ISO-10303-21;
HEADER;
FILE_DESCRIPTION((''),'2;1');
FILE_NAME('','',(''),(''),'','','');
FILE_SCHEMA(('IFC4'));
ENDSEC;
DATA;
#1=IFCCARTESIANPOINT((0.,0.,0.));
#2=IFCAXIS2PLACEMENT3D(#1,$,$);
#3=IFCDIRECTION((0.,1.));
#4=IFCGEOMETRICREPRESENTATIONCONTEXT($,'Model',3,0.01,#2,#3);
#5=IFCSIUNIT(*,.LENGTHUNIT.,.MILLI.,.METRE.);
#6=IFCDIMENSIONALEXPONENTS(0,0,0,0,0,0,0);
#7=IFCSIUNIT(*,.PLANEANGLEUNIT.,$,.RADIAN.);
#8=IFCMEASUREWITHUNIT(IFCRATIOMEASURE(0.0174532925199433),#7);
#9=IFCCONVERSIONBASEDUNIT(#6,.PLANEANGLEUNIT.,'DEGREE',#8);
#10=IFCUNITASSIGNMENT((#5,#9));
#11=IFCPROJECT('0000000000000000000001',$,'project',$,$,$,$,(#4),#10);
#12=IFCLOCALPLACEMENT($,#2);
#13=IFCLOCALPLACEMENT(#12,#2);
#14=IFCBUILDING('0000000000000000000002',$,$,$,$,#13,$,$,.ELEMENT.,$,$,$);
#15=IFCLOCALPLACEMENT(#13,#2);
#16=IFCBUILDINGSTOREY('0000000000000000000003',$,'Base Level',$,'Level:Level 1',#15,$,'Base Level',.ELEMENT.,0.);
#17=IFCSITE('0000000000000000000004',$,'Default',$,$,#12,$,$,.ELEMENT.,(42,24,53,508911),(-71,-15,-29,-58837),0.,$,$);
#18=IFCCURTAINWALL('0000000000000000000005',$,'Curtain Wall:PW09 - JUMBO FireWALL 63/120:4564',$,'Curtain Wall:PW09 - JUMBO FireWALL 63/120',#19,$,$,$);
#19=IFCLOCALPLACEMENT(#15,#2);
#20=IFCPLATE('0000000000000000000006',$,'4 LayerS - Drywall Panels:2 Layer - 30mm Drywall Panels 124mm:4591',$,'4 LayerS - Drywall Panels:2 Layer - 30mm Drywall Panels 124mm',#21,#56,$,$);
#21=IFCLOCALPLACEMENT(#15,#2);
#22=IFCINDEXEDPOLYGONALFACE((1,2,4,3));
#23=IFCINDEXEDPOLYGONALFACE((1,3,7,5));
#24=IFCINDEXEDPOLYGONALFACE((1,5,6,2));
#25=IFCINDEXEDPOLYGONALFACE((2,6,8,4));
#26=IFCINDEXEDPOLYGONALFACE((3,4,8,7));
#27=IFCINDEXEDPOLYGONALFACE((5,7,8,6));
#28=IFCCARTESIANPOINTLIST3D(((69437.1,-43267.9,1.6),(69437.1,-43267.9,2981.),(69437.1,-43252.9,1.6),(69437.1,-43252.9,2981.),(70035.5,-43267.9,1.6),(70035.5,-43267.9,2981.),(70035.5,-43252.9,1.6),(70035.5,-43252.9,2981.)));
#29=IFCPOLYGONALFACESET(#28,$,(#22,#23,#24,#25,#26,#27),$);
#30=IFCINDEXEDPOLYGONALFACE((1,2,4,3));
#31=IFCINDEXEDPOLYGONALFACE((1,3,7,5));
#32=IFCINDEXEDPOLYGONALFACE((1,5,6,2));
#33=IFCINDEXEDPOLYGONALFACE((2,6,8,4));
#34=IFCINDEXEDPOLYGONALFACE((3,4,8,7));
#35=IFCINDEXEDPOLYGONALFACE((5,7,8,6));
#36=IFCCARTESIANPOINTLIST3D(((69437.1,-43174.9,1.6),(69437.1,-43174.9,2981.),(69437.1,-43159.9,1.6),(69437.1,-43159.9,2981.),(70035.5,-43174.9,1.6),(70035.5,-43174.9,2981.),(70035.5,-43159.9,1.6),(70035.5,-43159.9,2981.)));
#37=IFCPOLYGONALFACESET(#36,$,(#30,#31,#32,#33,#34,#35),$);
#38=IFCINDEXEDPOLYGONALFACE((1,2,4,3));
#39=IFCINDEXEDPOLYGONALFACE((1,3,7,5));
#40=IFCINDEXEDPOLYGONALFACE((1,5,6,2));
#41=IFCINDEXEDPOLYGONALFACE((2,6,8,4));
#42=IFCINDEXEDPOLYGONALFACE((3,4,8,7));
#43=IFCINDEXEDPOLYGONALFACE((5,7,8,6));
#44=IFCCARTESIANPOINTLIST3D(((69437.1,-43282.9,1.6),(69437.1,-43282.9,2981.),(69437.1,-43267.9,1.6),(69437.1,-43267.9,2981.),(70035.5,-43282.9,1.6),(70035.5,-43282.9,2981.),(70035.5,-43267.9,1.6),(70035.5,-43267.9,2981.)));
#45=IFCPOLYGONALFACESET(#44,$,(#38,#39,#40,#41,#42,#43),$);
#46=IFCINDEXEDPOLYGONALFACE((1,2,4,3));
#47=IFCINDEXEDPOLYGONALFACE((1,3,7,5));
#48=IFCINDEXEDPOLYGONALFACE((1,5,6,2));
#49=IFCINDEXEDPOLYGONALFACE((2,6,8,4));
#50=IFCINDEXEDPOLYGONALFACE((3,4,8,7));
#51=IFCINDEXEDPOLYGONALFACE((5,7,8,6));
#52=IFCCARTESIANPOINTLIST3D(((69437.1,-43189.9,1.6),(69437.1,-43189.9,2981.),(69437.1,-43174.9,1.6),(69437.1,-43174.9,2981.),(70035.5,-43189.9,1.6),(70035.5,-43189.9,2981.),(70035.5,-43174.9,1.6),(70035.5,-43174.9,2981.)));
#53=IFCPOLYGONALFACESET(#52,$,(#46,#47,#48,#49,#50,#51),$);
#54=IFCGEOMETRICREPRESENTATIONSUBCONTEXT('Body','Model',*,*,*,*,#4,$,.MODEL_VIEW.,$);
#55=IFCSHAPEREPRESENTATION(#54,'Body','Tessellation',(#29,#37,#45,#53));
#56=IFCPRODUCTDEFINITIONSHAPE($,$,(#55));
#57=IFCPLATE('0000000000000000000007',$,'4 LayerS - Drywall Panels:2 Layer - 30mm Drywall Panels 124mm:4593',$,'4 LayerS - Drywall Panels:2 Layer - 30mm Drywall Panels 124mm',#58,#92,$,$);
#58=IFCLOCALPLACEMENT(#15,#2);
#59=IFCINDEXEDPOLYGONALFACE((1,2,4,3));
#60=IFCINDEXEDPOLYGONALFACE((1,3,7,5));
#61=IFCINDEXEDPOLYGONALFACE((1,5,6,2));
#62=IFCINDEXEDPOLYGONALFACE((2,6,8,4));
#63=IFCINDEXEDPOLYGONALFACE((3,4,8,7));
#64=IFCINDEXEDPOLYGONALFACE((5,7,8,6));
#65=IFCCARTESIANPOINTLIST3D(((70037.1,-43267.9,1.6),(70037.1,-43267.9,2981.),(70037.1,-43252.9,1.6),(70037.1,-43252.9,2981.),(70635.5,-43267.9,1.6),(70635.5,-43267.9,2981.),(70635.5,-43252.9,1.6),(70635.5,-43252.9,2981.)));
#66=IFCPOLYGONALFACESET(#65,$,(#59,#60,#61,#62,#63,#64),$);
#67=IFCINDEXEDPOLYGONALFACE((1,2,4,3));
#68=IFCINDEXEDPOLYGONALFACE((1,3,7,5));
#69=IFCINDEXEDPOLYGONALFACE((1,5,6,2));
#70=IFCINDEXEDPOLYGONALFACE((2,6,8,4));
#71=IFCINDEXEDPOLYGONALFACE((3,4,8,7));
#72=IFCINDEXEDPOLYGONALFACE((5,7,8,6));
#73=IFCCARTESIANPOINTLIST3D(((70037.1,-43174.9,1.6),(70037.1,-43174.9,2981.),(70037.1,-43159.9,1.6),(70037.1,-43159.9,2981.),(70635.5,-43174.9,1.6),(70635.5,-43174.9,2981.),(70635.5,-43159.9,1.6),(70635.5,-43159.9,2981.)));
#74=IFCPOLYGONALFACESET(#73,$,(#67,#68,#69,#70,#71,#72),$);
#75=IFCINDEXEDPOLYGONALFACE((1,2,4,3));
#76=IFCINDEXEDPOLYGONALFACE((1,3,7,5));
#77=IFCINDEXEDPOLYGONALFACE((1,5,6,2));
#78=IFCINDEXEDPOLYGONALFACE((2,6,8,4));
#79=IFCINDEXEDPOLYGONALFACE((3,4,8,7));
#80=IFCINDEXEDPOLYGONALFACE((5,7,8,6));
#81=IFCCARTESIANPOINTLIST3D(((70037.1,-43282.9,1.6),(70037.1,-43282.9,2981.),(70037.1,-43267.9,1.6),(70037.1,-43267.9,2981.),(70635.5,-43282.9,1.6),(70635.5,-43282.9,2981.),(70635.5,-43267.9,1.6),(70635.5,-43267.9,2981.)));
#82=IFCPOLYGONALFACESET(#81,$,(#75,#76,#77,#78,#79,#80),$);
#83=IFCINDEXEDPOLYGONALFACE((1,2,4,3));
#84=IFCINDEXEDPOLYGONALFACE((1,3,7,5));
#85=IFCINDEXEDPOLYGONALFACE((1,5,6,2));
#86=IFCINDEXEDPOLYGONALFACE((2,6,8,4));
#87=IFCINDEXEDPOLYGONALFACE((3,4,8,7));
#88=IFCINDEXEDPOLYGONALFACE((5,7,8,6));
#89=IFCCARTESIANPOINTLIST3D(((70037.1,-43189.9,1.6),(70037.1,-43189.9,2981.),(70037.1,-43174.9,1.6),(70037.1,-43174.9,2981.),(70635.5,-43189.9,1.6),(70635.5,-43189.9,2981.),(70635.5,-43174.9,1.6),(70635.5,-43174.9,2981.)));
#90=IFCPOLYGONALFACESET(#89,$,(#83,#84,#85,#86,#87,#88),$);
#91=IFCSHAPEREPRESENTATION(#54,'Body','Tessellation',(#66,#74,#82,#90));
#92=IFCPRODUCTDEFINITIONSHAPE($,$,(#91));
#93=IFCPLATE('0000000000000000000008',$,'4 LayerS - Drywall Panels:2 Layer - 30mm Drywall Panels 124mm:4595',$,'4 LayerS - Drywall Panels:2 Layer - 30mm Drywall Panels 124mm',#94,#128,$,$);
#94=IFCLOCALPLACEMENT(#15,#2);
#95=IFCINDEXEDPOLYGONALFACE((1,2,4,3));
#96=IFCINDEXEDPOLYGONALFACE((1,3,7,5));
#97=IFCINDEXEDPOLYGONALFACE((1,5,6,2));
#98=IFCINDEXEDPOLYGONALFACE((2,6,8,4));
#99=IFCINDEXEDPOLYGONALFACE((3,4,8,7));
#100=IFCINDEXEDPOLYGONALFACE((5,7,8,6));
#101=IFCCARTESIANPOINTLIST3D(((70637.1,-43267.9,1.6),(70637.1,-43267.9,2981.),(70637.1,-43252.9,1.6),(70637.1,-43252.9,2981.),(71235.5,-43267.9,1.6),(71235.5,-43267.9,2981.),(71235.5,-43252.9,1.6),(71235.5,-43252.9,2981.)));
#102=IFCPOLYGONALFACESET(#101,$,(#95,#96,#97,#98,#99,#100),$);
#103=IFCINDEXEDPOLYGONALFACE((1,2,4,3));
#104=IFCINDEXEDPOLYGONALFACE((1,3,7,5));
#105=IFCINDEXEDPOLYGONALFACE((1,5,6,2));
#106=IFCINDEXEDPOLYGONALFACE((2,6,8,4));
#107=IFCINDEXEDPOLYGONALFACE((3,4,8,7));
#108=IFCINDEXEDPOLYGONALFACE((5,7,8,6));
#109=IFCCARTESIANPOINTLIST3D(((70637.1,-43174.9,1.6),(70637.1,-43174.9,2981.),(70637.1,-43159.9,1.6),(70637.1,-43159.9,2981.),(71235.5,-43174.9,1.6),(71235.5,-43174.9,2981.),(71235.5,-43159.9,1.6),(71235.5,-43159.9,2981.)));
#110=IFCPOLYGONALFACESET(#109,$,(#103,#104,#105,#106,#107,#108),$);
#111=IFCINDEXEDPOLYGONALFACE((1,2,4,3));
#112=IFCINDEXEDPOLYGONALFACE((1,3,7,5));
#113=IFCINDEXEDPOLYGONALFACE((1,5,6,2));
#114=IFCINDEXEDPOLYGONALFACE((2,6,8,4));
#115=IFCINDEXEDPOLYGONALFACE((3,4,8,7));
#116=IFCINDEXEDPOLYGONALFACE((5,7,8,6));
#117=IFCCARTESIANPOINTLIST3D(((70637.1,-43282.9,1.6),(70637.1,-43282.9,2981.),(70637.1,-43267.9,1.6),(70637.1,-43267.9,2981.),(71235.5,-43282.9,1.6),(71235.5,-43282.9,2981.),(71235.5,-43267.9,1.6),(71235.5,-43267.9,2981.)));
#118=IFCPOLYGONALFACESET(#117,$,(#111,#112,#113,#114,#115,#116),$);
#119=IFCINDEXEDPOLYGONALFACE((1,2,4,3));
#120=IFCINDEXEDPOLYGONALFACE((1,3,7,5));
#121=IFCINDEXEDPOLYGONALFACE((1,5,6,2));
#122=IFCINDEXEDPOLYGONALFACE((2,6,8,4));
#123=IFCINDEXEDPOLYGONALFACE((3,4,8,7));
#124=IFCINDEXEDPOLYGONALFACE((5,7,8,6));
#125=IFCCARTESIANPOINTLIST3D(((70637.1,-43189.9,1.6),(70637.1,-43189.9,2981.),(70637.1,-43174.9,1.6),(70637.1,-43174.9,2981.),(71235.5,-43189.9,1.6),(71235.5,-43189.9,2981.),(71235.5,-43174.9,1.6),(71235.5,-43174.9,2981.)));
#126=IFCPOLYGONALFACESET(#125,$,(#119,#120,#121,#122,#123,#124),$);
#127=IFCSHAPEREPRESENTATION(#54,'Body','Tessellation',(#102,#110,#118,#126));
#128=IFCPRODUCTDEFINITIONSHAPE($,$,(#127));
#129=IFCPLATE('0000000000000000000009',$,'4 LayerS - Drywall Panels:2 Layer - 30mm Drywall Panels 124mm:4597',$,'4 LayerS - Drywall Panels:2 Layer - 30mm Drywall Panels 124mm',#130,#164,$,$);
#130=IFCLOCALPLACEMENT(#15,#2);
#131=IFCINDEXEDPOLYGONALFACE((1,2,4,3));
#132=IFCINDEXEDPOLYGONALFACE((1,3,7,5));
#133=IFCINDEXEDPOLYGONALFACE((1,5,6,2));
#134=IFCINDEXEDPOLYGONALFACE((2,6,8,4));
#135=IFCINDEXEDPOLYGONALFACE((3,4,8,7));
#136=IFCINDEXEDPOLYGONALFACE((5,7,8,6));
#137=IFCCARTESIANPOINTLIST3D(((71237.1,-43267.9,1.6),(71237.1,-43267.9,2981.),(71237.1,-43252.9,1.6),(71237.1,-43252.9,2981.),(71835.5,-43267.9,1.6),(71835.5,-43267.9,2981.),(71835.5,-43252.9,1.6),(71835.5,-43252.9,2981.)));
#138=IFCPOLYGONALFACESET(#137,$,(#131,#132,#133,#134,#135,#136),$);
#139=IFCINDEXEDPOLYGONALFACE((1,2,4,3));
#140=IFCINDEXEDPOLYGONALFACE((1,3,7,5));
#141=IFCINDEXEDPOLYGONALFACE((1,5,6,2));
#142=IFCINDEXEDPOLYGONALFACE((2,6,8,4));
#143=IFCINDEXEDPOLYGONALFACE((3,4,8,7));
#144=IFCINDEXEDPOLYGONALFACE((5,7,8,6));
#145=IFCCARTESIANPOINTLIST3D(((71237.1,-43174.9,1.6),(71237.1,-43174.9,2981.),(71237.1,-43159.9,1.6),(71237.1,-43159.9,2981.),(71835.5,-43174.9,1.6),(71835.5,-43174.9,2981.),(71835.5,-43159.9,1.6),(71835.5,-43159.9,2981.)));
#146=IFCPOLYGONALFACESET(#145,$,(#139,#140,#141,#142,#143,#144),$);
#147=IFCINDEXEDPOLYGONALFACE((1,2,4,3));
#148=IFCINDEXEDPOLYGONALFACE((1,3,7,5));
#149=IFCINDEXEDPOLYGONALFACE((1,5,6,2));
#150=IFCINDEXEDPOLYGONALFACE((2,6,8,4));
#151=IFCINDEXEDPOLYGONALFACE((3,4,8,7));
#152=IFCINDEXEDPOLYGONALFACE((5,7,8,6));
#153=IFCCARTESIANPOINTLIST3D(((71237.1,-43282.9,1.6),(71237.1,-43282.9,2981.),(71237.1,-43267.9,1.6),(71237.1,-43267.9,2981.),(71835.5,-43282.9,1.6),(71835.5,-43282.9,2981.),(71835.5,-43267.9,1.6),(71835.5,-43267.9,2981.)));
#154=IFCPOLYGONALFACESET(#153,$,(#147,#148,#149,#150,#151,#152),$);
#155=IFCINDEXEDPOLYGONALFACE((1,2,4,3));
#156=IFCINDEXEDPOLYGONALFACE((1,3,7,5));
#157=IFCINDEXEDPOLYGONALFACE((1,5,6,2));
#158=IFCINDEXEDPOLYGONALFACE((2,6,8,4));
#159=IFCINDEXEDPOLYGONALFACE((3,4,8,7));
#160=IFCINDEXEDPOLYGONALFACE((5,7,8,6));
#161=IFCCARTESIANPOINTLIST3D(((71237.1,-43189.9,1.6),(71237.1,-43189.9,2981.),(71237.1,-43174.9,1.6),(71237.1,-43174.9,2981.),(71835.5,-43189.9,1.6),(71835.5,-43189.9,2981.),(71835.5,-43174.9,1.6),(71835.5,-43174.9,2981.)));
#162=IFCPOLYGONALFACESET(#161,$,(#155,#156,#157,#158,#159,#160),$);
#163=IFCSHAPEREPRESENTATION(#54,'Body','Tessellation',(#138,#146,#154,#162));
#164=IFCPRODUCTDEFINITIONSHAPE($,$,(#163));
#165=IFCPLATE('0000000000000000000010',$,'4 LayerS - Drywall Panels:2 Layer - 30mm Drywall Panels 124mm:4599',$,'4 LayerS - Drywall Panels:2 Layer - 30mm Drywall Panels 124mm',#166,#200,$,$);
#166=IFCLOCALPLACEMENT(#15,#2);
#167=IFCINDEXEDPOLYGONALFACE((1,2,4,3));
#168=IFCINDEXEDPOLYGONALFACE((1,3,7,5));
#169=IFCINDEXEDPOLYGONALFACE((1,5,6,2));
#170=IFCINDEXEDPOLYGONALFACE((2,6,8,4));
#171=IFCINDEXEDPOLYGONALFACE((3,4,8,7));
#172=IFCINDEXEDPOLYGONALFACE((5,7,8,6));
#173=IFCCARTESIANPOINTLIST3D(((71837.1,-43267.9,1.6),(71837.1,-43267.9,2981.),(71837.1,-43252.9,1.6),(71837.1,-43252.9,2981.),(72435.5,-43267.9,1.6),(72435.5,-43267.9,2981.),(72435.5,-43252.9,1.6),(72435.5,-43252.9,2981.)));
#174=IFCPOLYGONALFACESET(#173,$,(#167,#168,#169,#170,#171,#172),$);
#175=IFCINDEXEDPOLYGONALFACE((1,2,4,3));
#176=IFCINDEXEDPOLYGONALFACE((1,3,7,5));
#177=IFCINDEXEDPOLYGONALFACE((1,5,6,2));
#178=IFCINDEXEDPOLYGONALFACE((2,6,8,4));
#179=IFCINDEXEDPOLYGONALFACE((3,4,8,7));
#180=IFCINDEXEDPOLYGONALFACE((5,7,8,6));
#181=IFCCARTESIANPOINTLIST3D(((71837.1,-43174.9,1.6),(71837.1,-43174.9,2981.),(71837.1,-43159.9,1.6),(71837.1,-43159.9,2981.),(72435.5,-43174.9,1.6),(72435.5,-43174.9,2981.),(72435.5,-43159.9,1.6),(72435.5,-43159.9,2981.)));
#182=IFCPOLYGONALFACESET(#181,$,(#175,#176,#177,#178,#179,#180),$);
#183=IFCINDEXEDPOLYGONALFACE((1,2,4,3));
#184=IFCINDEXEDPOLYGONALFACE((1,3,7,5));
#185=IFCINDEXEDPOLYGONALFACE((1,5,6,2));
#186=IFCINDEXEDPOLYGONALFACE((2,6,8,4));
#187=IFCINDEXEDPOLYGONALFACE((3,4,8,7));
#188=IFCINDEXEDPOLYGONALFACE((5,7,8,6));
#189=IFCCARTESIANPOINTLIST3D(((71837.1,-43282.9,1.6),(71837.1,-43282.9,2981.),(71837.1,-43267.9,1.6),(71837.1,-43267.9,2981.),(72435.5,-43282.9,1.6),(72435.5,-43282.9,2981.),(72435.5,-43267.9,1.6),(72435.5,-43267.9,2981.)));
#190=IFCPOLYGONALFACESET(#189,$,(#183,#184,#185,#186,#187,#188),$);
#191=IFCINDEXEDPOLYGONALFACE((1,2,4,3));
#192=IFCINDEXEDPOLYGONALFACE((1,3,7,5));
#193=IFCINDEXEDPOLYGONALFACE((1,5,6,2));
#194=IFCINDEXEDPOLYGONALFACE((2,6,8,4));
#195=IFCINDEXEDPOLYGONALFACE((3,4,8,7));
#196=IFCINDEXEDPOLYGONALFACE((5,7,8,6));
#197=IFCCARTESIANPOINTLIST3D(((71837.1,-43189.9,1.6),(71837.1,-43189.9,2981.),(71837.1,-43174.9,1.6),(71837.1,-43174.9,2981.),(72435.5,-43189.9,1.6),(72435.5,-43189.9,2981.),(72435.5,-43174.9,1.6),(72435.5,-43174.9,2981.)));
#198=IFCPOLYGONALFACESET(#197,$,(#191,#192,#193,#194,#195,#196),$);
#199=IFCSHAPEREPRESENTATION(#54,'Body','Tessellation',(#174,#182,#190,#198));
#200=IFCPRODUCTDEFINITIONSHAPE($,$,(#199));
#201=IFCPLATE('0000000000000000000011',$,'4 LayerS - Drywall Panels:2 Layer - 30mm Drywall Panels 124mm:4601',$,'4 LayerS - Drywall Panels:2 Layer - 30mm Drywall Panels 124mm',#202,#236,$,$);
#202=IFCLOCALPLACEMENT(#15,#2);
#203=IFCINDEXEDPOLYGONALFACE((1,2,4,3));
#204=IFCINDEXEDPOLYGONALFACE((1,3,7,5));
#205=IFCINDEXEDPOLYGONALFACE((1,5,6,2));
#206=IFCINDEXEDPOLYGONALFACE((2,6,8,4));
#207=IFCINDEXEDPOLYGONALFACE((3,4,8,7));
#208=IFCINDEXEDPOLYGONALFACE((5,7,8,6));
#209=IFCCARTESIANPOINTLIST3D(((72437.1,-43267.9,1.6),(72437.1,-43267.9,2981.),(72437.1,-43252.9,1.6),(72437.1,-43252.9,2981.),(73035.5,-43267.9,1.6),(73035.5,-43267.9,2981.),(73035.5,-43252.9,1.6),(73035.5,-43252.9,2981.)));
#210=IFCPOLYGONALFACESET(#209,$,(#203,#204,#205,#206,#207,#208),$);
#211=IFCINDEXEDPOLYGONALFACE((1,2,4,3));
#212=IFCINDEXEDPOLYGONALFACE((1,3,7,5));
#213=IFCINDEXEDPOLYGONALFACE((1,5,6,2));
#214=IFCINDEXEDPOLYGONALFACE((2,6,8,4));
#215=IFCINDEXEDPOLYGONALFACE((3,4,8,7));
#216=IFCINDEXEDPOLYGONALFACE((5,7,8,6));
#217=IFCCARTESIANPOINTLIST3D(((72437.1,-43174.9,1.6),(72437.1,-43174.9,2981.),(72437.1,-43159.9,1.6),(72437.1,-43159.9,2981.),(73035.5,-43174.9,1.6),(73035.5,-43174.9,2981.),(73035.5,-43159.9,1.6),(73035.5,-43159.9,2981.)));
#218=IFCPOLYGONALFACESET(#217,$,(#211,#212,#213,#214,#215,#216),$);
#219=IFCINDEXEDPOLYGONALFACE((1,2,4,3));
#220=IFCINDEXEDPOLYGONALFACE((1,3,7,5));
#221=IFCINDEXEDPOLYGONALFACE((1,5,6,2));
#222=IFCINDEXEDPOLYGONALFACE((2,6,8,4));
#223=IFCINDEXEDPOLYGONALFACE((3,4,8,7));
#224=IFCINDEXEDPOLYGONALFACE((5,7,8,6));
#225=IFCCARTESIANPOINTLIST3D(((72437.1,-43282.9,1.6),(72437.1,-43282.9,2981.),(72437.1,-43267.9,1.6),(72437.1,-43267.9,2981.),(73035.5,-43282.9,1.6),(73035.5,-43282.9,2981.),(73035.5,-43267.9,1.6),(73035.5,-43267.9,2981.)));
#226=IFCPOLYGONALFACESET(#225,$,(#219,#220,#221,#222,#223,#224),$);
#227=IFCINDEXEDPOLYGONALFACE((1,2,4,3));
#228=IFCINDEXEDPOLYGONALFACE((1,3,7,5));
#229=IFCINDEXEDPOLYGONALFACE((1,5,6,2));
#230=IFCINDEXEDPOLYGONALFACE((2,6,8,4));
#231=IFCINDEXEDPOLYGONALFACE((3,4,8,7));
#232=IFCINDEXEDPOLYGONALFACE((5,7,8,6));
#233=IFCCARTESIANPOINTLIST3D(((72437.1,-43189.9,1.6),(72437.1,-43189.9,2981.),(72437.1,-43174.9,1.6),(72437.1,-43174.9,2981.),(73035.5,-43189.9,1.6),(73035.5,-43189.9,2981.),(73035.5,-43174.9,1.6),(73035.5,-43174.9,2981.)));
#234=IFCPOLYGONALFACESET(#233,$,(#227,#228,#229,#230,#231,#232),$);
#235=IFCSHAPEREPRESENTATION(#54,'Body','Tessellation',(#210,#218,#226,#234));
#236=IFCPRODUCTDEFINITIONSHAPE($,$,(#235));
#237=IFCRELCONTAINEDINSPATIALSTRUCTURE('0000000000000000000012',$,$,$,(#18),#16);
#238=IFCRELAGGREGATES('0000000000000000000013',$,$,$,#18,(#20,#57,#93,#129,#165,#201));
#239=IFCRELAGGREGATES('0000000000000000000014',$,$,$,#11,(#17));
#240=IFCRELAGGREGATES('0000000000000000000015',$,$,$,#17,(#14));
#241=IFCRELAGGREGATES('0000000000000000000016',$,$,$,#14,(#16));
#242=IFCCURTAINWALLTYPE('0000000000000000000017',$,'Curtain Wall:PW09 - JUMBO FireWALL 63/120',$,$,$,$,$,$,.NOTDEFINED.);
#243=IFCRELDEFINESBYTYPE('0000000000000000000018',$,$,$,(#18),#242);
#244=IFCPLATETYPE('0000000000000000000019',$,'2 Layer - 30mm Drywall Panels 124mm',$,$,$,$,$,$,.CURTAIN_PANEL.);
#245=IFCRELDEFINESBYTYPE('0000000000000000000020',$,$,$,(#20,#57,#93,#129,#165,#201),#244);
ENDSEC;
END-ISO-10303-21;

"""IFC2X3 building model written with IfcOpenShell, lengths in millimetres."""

from ifc_helpers import new_model, entity, si_unit, converted_unit, direction, frame, frame_2d, origin, origin_2d_with_axis, place, context, subcontext, project, spatial, rectangle, extrude, source, transform, mapped, type_object, type_shapes, element, aggregate, save


model = new_model("IFC2X3")

# Units and contexts
model_context = context("Model", 3, precision=0.01, world=origin(), true_north=direction((0.0, 1.0)))
body_context = subcontext(model_context, "Body", "Model", "MODEL_VIEW")
ifc_project = project(units=[si_unit("LENGTHUNIT", "METRE", prefix="MILLI"), converted_unit("PLANEANGLEUNIT", "DEGREE", entity("IfcRatioMeasure", 0.0174532925199433), si_unit("PLANEANGLEUNIT", "RADIAN"), dimensions=[0, 0, 0, 0, 0, 0, 0])], contexts=[model_context])

# Site, building, storey
site_placement = place(None, origin())
site = spatial("IfcSite", under=ifc_project, at=site_placement, Name="Default", CompositionType="ELEMENT", RefLatitude=(42, 24, 53, 508911), RefLongitude=(-71, -15, -29, -58837), RefElevation=0.0)
building_placement = place(site_placement, origin())
building = spatial("IfcBuilding", under=site, at=building_placement, CompositionType="ELEMENT")
storey_placement = place(building_placement, origin())
storey = spatial("IfcBuildingStorey", under=building, at=storey_placement, Name="Base Level", ObjectType="Level:Level 1", LongName="Base Level", CompositionType="ELEMENT", Elevation=0.0)

# Curtain wall, plates
curtain_wall_type = type_object("IfcCurtainWallType", Name="Curtain Wall:PW09 - JUMBO FireWALL 63/120", PredefinedType="NOTDEFINED")
curtain_wall_placement = place(building_placement, origin())
curtain_wall = element("IfcCurtainWall", 1, at=curtain_wall_placement, inside=storey, type_object=curtain_wall_type, Name="Curtain Wall:PW09 - JUMBO FireWALL 63/120:4564", ObjectType="Curtain Wall:PW09 - JUMBO FireWALL 63/120")
plate_type = type_object("IfcPlateType", Name="2 Layer - 30mm Drywall Panels 124mm", PredefinedType="CURTAIN_PANEL")
shared_shape_1 = source(origin(), body_context, "Body", "SweptSolid", [
    extrude(rectangle(XDim=15.0, YDim=598.4, at=origin_2d_with_axis()), frame((0.0, -39.0, 0.0), z_axis=(0.0, 0.0, 1.0), x_axis=(0.0, 1.0, 0.0)), (0.0, 0.0, 1.0), 2979.4),
    extrude(rectangle(XDim=15.0, YDim=598.4, at=origin_2d_with_axis()), frame((0.0, 54.0, 0.0), z_axis=(0.0, 0.0, 1.0), x_axis=(0.0, 1.0, 0.0)), (0.0, 0.0, 1.0), 2979.4),
    extrude(rectangle(XDim=598.4, YDim=15.0, at=frame_2d((0.0, 0.0), x_axis=(1.0, 0.0))), frame((0.0, -54.0, 0.0), z_axis=(0.0, 0.0, 1.0), x_axis=(-1.0, 0.0, 0.0)), (0.0, 0.0, 1.0), 2979.4),
    extrude(rectangle(XDim=15.0, YDim=598.4, at=frame_2d((0.0, 0.0), x_axis=(1.0, 0.0))), frame((0.0, 39.0, 0.0), z_axis=(0.0, 0.0, 1.0), x_axis=(0.0, 1.0, 0.0)), (0.0, 0.0, 1.0), 2979.4),
])
type_shapes(plate_type, [shared_shape_1])
plate_1_placement = place(curtain_wall_placement, frame((69736.3, -43221.4, 1.6)))
plate_1 = element("IfcPlate", 2, at=plate_1_placement, type_object=plate_type, Name="4 LayerS - Drywall Panels:2 Layer - 30mm Drywall Panels 124mm:4591", ObjectType="4 LayerS - Drywall Panels:2 Layer - 30mm Drywall Panels 124mm", context=body_context, shape_type="MappedRepresentation", body=[
    mapped(shared_shape_1, transform((0.0, 0.0, 0.0), scale=1.0)),
])
plate_2_placement = place(curtain_wall_placement, frame((70336.3, -43221.4, 1.6)))
plate_2 = element("IfcPlate", 3, at=plate_2_placement, type_object=plate_type, Name="4 LayerS - Drywall Panels:2 Layer - 30mm Drywall Panels 124mm:4593", ObjectType="4 LayerS - Drywall Panels:2 Layer - 30mm Drywall Panels 124mm", context=body_context, shape_type="MappedRepresentation", body=[
    mapped(shared_shape_1, transform((0.0, 0.0, 0.0), scale=1.0)),
])
plate_3_placement = place(curtain_wall_placement, frame((70936.3, -43221.4, 1.6)))
plate_3 = element("IfcPlate", 4, at=plate_3_placement, type_object=plate_type, Name="4 LayerS - Drywall Panels:2 Layer - 30mm Drywall Panels 124mm:4595", ObjectType="4 LayerS - Drywall Panels:2 Layer - 30mm Drywall Panels 124mm", context=body_context, shape_type="MappedRepresentation", body=[
    mapped(shared_shape_1, transform((0.0, 0.0, 0.0), scale=1.0)),
])
plate_4_placement = place(curtain_wall_placement, frame((71536.3, -43221.4, 1.6)))
plate_4 = element("IfcPlate", 5, at=plate_4_placement, type_object=plate_type, Name="4 LayerS - Drywall Panels:2 Layer - 30mm Drywall Panels 124mm:4597", ObjectType="4 LayerS - Drywall Panels:2 Layer - 30mm Drywall Panels 124mm", context=body_context, shape_type="MappedRepresentation", body=[
    mapped(shared_shape_1, transform((0.0, 0.0, 0.0), scale=1.0)),
])
plate_5_placement = place(curtain_wall_placement, frame((72136.3, -43221.4, 1.6)))
plate_5 = element("IfcPlate", 6, at=plate_5_placement, type_object=plate_type, Name="4 LayerS - Drywall Panels:2 Layer - 30mm Drywall Panels 124mm:4599", ObjectType="4 LayerS - Drywall Panels:2 Layer - 30mm Drywall Panels 124mm", context=body_context, shape_type="MappedRepresentation", body=[
    mapped(shared_shape_1, transform((0.0, 0.0, 0.0), scale=1.0)),
])
plate_6_placement = place(curtain_wall_placement, frame((72736.3, -43221.4, 1.6)))
plate_6 = element("IfcPlate", 7, at=plate_6_placement, type_object=plate_type, Name="4 LayerS - Drywall Panels:2 Layer - 30mm Drywall Panels 124mm:4601", ObjectType="4 LayerS - Drywall Panels:2 Layer - 30mm Drywall Panels 124mm", context=body_context, shape_type="MappedRepresentation", body=[
    mapped(shared_shape_1, transform((0.0, 0.0, 0.0), scale=1.0)),
])
aggregate(curtain_wall, [plate_1, plate_2, plate_3, plate_4, plate_5, plate_6])

save(model, "model.ifc")
